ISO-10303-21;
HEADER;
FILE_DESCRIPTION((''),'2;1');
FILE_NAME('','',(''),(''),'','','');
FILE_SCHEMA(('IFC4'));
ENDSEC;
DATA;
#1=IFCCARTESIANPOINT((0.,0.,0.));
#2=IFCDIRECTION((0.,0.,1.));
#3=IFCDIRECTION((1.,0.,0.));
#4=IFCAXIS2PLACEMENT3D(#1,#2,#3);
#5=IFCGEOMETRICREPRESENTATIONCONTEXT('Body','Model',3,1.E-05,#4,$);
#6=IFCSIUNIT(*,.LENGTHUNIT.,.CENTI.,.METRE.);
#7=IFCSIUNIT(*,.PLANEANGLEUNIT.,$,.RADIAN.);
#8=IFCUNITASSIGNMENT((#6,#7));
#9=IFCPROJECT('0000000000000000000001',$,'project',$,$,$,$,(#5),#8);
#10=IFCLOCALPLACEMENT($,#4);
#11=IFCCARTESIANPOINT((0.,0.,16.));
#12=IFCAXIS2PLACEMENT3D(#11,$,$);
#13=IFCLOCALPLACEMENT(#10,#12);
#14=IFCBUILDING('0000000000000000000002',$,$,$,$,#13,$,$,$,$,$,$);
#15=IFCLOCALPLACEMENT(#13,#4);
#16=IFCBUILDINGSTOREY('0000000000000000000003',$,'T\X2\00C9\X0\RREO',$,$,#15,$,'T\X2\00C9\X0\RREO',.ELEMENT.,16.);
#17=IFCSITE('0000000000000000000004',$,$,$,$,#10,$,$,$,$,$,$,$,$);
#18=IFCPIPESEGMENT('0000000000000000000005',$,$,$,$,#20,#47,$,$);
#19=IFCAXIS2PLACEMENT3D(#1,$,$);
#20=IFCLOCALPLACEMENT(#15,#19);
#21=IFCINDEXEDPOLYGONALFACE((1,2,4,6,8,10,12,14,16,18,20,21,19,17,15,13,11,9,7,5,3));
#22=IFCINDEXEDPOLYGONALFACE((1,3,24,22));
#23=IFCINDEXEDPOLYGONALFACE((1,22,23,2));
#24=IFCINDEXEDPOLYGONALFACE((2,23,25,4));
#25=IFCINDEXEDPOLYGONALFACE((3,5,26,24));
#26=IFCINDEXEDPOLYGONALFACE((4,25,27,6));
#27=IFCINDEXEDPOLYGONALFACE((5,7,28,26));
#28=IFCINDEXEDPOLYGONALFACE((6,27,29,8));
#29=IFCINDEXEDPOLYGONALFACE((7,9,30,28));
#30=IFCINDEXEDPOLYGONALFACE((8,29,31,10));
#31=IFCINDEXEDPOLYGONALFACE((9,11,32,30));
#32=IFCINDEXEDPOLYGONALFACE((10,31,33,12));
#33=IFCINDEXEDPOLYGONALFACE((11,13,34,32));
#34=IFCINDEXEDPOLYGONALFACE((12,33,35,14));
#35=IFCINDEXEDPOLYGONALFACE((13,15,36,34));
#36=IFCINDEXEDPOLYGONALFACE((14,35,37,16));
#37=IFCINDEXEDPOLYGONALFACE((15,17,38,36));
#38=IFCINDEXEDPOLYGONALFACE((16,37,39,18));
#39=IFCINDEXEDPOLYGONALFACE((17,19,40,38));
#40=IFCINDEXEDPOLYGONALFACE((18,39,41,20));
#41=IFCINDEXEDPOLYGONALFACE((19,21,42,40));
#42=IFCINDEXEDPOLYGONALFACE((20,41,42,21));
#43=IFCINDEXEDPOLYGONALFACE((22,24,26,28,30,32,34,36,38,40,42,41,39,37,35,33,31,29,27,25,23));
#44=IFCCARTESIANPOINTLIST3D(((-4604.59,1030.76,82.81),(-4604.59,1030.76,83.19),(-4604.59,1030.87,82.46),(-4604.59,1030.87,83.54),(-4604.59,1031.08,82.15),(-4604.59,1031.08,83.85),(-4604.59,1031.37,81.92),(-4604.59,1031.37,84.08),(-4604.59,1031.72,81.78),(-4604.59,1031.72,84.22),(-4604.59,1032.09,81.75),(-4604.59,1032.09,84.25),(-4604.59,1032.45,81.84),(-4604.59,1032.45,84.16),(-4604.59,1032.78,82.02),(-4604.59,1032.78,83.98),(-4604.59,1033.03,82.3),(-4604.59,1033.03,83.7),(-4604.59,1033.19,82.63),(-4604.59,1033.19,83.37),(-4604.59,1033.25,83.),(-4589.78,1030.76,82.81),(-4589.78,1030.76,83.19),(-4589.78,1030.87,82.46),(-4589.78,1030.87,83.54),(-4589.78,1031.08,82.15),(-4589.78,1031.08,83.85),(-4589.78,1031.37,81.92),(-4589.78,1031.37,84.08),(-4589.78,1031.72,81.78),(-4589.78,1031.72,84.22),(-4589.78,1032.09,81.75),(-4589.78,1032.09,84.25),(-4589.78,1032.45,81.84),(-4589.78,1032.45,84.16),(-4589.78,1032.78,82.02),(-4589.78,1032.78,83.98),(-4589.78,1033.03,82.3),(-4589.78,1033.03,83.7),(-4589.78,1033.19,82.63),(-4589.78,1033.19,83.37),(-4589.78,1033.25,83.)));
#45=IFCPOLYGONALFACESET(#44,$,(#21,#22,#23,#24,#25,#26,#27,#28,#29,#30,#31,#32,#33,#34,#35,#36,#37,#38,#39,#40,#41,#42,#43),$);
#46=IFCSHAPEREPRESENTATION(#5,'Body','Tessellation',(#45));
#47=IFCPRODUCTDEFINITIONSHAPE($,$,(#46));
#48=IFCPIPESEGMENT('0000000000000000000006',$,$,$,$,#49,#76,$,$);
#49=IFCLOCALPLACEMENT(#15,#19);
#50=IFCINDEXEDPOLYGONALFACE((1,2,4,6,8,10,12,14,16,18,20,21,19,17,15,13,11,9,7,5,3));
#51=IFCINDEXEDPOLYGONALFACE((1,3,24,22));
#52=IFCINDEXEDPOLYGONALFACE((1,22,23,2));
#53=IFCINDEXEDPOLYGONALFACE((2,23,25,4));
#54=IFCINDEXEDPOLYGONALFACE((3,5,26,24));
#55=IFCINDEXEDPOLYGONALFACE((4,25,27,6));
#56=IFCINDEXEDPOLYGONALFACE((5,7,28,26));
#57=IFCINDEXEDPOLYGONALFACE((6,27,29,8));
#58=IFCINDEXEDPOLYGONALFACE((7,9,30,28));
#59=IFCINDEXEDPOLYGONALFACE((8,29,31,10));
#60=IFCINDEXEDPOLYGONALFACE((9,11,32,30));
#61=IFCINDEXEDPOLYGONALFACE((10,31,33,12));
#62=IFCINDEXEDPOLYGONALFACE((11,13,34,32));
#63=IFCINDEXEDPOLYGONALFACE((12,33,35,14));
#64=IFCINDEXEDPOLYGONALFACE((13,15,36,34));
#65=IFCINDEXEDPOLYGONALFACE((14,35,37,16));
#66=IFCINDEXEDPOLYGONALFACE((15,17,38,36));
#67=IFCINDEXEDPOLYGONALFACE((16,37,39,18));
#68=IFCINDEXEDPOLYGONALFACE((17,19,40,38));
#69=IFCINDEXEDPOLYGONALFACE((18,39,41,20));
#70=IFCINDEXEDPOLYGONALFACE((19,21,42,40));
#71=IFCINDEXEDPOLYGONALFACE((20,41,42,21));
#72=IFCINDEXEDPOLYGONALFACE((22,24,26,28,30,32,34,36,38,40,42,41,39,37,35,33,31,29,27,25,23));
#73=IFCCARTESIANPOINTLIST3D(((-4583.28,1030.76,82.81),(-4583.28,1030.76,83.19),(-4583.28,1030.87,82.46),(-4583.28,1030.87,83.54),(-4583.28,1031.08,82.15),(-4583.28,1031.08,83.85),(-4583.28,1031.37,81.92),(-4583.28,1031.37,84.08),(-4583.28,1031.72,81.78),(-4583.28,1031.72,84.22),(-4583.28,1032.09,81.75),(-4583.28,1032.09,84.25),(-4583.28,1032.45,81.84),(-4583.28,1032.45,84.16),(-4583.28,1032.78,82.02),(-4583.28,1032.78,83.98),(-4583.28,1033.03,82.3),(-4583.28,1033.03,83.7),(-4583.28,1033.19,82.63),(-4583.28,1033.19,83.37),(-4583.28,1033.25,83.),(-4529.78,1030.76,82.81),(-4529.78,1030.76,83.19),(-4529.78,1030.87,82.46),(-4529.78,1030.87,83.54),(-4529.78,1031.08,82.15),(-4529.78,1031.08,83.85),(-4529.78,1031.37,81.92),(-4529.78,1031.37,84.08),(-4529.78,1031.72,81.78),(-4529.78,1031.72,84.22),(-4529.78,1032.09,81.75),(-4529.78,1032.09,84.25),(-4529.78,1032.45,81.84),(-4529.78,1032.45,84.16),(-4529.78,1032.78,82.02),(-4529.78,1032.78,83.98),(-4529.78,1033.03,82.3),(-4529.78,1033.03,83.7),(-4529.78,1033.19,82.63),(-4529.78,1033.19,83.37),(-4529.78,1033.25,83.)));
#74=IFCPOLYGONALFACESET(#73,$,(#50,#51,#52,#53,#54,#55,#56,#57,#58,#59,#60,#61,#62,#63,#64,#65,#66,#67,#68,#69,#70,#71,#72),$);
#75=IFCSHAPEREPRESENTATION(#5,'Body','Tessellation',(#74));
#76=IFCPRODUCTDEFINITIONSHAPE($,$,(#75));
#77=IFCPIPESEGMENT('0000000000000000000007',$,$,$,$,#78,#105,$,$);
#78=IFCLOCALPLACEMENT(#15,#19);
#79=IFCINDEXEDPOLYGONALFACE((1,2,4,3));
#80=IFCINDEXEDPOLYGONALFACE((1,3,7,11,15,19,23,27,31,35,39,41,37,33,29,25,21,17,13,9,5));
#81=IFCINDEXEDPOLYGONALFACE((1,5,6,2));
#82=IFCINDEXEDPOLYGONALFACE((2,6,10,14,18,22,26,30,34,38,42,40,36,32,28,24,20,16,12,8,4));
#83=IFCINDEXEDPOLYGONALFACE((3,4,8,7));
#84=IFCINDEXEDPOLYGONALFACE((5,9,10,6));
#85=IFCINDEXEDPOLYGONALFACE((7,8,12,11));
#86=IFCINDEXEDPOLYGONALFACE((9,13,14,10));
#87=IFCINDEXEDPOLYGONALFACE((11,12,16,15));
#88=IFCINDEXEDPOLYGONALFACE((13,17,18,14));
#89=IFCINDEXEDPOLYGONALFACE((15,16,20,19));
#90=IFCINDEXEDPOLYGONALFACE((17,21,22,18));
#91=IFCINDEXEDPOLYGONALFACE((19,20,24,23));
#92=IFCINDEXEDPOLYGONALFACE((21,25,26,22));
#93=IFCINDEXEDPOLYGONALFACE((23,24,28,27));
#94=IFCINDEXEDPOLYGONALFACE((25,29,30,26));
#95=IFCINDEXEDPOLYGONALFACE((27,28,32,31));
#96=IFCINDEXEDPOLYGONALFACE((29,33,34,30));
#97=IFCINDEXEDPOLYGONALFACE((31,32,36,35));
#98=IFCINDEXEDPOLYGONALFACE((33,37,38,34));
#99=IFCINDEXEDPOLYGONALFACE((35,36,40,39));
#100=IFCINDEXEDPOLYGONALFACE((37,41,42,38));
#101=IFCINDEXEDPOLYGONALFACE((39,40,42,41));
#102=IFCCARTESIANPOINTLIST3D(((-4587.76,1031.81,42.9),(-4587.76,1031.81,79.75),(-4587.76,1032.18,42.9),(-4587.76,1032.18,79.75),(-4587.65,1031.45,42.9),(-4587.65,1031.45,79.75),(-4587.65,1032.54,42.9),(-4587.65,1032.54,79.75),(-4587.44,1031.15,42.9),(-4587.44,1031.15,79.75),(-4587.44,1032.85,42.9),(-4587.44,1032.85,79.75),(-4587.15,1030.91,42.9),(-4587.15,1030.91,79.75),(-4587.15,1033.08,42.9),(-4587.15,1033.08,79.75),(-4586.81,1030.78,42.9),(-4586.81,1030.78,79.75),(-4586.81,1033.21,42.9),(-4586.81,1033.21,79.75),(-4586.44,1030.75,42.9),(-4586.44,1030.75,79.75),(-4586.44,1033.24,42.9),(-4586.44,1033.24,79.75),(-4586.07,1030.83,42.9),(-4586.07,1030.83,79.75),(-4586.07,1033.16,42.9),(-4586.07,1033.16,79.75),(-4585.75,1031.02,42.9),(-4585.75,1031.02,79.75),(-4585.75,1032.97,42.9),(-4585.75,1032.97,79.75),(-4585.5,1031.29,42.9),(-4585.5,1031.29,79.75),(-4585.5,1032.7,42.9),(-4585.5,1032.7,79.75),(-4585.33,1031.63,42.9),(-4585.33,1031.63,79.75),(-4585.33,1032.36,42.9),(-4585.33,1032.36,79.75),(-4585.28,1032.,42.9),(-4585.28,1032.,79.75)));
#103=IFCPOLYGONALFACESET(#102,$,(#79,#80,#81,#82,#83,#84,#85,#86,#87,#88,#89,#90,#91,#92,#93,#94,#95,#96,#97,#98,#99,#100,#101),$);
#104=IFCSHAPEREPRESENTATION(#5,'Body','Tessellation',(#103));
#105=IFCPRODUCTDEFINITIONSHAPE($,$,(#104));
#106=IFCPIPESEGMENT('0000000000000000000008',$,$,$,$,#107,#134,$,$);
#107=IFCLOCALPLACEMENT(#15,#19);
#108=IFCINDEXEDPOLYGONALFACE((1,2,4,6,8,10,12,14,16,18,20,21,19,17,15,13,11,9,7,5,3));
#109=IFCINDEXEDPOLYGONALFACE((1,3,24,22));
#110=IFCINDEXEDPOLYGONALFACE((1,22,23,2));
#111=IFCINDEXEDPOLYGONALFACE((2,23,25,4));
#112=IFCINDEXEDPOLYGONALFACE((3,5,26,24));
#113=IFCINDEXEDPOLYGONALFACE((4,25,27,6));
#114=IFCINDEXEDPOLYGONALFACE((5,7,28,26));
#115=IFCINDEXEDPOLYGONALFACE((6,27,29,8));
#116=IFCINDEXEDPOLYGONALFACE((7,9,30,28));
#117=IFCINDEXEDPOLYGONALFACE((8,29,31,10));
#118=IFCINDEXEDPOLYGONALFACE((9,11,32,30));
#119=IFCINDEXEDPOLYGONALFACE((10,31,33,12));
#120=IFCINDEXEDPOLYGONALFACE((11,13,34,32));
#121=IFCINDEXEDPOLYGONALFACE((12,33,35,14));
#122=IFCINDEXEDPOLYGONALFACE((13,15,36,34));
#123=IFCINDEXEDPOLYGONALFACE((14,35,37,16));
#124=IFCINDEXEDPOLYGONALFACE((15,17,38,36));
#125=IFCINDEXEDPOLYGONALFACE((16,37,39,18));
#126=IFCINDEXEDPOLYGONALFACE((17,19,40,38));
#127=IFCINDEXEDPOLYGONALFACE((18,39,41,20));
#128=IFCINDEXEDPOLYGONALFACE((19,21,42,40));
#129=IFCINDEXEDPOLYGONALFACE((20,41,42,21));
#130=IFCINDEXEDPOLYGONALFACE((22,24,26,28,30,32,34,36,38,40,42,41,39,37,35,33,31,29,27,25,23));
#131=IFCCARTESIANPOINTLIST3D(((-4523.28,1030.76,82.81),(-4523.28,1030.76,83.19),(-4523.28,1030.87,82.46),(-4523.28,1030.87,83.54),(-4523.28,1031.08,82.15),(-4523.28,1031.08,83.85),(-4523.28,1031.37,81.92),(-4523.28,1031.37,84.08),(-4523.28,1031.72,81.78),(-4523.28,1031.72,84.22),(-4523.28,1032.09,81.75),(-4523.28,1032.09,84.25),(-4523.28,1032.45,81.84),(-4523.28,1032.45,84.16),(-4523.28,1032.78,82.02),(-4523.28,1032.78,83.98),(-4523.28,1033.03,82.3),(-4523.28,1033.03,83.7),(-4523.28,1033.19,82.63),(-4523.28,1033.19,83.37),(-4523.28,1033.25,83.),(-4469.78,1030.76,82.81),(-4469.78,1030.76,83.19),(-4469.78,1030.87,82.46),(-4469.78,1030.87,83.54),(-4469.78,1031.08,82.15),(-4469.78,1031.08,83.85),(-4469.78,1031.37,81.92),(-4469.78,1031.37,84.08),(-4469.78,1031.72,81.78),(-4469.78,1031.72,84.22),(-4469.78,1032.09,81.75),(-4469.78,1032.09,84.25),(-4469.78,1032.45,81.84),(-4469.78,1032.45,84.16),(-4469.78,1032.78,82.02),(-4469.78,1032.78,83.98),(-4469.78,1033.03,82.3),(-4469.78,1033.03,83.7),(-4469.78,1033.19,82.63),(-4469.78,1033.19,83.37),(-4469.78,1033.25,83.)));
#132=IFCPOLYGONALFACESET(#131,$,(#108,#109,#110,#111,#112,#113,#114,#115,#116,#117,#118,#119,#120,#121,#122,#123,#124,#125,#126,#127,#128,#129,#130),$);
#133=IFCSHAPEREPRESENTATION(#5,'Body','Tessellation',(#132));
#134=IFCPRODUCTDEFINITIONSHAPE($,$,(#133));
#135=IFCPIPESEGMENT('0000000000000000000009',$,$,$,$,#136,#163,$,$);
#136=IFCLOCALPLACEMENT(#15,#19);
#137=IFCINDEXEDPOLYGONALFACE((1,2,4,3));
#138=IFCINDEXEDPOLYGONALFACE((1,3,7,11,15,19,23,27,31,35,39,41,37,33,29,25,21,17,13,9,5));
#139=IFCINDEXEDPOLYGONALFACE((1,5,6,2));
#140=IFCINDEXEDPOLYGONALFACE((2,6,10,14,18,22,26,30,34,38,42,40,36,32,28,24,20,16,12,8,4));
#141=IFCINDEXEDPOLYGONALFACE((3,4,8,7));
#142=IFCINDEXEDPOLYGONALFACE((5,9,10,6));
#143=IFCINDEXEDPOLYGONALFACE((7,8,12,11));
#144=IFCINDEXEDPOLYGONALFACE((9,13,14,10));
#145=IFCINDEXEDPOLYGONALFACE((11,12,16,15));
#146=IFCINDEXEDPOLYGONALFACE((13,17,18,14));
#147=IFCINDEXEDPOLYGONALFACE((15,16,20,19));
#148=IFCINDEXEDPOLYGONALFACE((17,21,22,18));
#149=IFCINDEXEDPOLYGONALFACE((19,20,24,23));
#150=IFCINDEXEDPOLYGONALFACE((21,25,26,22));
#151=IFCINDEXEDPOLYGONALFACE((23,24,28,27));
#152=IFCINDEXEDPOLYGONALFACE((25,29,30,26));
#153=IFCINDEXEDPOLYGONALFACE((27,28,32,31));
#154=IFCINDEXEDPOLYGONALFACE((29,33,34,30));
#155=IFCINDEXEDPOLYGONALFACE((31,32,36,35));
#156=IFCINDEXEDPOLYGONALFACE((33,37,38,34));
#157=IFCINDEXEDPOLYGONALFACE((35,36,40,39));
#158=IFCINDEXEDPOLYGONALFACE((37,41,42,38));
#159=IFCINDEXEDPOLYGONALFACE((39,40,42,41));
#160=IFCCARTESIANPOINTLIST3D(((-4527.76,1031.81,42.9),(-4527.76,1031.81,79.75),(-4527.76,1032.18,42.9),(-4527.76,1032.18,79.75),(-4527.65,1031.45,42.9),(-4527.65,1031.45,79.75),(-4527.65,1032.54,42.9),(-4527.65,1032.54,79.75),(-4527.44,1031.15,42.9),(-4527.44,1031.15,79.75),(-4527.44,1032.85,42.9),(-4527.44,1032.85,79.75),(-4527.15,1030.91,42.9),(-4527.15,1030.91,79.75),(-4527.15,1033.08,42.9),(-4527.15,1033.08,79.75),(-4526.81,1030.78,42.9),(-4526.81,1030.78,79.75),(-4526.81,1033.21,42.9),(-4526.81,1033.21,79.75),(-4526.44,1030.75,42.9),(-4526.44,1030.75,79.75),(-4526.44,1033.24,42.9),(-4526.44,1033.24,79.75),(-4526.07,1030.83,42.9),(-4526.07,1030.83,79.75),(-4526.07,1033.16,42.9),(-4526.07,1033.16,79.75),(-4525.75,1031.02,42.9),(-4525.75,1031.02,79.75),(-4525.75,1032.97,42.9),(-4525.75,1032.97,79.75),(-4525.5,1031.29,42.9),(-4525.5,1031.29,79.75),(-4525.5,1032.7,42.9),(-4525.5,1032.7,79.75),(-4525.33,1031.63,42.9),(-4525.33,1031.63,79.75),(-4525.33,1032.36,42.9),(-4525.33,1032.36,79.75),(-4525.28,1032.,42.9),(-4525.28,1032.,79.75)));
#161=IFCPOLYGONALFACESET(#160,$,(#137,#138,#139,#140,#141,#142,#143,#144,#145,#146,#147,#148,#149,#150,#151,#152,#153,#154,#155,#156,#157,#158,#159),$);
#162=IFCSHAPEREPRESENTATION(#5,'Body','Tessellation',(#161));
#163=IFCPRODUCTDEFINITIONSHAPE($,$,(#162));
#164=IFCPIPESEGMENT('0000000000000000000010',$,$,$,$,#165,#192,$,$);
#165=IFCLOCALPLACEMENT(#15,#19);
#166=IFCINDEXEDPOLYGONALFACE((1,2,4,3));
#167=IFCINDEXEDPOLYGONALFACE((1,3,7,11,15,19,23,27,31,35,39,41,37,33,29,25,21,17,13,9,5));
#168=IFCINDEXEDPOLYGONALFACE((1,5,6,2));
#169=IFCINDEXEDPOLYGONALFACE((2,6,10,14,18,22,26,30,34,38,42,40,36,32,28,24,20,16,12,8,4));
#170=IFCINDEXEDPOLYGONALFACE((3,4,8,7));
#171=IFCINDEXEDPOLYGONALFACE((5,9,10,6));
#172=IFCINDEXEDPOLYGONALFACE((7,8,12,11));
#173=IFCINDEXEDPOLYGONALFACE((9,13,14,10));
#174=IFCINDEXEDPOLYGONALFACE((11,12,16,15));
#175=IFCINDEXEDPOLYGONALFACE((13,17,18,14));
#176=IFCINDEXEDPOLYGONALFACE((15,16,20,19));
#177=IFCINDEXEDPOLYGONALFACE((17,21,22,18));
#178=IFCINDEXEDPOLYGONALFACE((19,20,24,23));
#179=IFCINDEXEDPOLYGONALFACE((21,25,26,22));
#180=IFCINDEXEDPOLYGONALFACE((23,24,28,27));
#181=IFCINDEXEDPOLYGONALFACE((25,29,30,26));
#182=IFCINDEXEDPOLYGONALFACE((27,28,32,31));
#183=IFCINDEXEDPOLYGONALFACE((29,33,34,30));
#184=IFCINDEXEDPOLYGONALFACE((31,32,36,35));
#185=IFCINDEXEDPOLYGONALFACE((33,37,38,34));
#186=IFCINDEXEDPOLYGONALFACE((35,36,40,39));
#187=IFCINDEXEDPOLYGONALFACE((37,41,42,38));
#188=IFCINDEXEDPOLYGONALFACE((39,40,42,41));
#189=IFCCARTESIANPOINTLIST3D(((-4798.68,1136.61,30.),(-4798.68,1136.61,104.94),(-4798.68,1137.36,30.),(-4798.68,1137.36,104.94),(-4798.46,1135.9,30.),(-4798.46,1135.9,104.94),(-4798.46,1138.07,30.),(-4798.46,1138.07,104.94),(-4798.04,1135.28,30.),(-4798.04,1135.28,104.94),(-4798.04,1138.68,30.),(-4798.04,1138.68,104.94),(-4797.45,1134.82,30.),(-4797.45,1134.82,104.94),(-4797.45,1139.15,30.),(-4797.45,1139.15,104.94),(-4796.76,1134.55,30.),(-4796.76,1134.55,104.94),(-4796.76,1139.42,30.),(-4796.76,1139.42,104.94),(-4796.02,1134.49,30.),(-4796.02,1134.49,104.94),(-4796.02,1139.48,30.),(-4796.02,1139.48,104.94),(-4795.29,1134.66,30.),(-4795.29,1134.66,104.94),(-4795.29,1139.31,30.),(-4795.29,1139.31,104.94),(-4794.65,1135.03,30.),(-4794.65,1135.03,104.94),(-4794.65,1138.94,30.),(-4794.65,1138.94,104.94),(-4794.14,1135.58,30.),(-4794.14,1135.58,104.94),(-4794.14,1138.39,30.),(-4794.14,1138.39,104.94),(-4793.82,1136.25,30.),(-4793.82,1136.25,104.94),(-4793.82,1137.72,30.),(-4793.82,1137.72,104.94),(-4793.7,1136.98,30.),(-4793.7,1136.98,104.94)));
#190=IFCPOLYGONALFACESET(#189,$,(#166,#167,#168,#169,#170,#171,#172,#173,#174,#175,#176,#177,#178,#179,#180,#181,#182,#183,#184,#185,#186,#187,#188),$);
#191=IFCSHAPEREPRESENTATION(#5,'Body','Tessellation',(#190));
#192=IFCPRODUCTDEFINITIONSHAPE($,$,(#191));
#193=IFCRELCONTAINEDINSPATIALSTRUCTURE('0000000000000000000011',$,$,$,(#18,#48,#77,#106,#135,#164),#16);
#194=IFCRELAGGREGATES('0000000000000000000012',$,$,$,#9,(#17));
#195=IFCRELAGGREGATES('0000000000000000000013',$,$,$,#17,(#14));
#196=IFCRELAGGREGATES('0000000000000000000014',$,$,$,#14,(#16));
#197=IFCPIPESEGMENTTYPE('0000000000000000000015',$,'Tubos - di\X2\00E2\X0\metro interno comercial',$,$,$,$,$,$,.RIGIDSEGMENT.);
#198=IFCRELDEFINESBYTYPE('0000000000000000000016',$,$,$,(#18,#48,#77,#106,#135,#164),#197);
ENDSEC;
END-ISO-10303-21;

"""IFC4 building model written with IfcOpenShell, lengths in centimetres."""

from ifc_helpers import new_model, si_unit, frame, origin_with_axes, origin_2d_with_axis, place, context, project, spatial, circle, extrude, type_object, element, save


model = new_model("IFC4")

# Units and contexts
model_context = context("Model", 3, precision=1e-05, world=origin_with_axes(), identifier="Body")
ifc_project = project(units=[si_unit("LENGTHUNIT", "METRE", prefix="CENTI"), si_unit("PLANEANGLEUNIT", "RADIAN")], contexts=[model_context])

# Site, building, storey
site_placement = place(None, origin_with_axes())
site = spatial("IfcSite", under=ifc_project, at=site_placement)
building_placement = place(site_placement, frame((0.0, 0.0, 16.0)))
building = spatial("IfcBuilding", under=site, at=building_placement)
storey_placement = place(building_placement, origin_with_axes())
storey = spatial("IfcBuildingStorey", under=building, at=storey_placement, Name="TÉRREO", LongName="TÉRREO", CompositionType="ELEMENT", Elevation=16.0)

# Pipe segments
pipe_segment_type = type_object("IfcPipeSegmentType", Name="Tubos - diâmetro interno comercial", PredefinedType="RIGIDSEGMENT")
pipe_segment_1_placement = place(storey_placement, frame((-4597.18, 1032.0, 84.25), z_axis=(0.0, 0.0, 1.0), x_axis=(1.0, 0.0, 0.0)))
element("IfcPipeSegment", 1, at=pipe_segment_1_placement, inside=storey, type_object=pipe_segment_type, context=model_context, shape_type="SolidModel", body=[
    extrude(circle(Radius=1.25, at=origin_2d_with_axis()), frame((-7.4, 0.0, -1.25), z_axis=(1.0, 0.0, 0.0), x_axis=(0.0, 1.0, 0.0)), (0.0, 0.0, 1.0), 14.81),
])
pipe_segment_2_placement = place(storey_placement, frame((-4556.53, 1032.0, 84.25), z_axis=(0.0, 0.0, 1.0), x_axis=(1.0, 0.0, 0.0)))
element("IfcPipeSegment", 2, at=pipe_segment_2_placement, inside=storey, type_object=pipe_segment_type, context=model_context, shape_type="SolidModel", body=[
    extrude(circle(Radius=1.25, at=origin_2d_with_axis()), frame((-26.75, 0.0, -1.25), z_axis=(1.0, 0.0, 0.0), x_axis=(0.0, 1.0, 0.0)), (0.0, 0.0, 1.0), 53.5),
])
pipe_segment_3_placement = place(storey_placement, frame((-4586.53, 1032.0, 79.75), z_axis=(0.0, 0.0, 1.0), x_axis=(1.0, 0.0, 0.0)))
element("IfcPipeSegment", 3, at=pipe_segment_3_placement, inside=storey, type_object=pipe_segment_type, context=model_context, shape_type="SolidModel", body=[
    extrude(circle(Radius=1.25, at=origin_2d_with_axis()), frame((0.0, 0.0, 0.0), z_axis=(0.0, 0.0, -1.0), x_axis=(1.0, 0.0, 0.0)), (0.0, 0.0, 1.0), 36.85),
])
pipe_segment_4_placement = place(storey_placement, frame((-4496.53, 1032.0, 84.25), z_axis=(0.0, 0.0, 1.0), x_axis=(1.0, 0.0, 0.0)))
element("IfcPipeSegment", 4, at=pipe_segment_4_placement, inside=storey, type_object=pipe_segment_type, context=model_context, shape_type="SolidModel", body=[
    extrude(circle(Radius=1.25, at=origin_2d_with_axis()), frame((-26.75, 0.0, -1.25), z_axis=(1.0, 0.0, 0.0), x_axis=(0.0, 1.0, 0.0)), (0.0, 0.0, 1.0), 53.5),
])
pipe_segment_5_placement = place(storey_placement, frame((-4526.53, 1032.0, 79.75), z_axis=(0.0, 0.0, 1.0), x_axis=(1.0, 0.0, 0.0)))
element("IfcPipeSegment", 5, at=pipe_segment_5_placement, inside=storey, type_object=pipe_segment_type, context=model_context, shape_type="SolidModel", body=[
    extrude(circle(Radius=1.25, at=origin_2d_with_axis()), frame((0.0, 0.0, 0.0), z_axis=(0.0, 0.0, -1.0), x_axis=(1.0, 0.0, 0.0)), (0.0, 0.0, 1.0), 36.85),
])
pipe_segment_6_placement = place(storey_placement, frame((-4796.2, 1136.98, 104.94), z_axis=(0.0, 0.0, 1.0), x_axis=(1.0, 0.0, 0.0)))
element("IfcPipeSegment", 6, at=pipe_segment_6_placement, inside=storey, type_object=pipe_segment_type, context=model_context, shape_type="SolidModel", body=[
    extrude(circle(Radius=2.5, at=origin_2d_with_axis()), frame((0.0, 0.0, 0.0), z_axis=(0.0, 0.0, -1.0), x_axis=(1.0, 0.0, 0.0)), (0.0, 0.0, 1.0), 74.94),
])

save(model, "model.ifc")
